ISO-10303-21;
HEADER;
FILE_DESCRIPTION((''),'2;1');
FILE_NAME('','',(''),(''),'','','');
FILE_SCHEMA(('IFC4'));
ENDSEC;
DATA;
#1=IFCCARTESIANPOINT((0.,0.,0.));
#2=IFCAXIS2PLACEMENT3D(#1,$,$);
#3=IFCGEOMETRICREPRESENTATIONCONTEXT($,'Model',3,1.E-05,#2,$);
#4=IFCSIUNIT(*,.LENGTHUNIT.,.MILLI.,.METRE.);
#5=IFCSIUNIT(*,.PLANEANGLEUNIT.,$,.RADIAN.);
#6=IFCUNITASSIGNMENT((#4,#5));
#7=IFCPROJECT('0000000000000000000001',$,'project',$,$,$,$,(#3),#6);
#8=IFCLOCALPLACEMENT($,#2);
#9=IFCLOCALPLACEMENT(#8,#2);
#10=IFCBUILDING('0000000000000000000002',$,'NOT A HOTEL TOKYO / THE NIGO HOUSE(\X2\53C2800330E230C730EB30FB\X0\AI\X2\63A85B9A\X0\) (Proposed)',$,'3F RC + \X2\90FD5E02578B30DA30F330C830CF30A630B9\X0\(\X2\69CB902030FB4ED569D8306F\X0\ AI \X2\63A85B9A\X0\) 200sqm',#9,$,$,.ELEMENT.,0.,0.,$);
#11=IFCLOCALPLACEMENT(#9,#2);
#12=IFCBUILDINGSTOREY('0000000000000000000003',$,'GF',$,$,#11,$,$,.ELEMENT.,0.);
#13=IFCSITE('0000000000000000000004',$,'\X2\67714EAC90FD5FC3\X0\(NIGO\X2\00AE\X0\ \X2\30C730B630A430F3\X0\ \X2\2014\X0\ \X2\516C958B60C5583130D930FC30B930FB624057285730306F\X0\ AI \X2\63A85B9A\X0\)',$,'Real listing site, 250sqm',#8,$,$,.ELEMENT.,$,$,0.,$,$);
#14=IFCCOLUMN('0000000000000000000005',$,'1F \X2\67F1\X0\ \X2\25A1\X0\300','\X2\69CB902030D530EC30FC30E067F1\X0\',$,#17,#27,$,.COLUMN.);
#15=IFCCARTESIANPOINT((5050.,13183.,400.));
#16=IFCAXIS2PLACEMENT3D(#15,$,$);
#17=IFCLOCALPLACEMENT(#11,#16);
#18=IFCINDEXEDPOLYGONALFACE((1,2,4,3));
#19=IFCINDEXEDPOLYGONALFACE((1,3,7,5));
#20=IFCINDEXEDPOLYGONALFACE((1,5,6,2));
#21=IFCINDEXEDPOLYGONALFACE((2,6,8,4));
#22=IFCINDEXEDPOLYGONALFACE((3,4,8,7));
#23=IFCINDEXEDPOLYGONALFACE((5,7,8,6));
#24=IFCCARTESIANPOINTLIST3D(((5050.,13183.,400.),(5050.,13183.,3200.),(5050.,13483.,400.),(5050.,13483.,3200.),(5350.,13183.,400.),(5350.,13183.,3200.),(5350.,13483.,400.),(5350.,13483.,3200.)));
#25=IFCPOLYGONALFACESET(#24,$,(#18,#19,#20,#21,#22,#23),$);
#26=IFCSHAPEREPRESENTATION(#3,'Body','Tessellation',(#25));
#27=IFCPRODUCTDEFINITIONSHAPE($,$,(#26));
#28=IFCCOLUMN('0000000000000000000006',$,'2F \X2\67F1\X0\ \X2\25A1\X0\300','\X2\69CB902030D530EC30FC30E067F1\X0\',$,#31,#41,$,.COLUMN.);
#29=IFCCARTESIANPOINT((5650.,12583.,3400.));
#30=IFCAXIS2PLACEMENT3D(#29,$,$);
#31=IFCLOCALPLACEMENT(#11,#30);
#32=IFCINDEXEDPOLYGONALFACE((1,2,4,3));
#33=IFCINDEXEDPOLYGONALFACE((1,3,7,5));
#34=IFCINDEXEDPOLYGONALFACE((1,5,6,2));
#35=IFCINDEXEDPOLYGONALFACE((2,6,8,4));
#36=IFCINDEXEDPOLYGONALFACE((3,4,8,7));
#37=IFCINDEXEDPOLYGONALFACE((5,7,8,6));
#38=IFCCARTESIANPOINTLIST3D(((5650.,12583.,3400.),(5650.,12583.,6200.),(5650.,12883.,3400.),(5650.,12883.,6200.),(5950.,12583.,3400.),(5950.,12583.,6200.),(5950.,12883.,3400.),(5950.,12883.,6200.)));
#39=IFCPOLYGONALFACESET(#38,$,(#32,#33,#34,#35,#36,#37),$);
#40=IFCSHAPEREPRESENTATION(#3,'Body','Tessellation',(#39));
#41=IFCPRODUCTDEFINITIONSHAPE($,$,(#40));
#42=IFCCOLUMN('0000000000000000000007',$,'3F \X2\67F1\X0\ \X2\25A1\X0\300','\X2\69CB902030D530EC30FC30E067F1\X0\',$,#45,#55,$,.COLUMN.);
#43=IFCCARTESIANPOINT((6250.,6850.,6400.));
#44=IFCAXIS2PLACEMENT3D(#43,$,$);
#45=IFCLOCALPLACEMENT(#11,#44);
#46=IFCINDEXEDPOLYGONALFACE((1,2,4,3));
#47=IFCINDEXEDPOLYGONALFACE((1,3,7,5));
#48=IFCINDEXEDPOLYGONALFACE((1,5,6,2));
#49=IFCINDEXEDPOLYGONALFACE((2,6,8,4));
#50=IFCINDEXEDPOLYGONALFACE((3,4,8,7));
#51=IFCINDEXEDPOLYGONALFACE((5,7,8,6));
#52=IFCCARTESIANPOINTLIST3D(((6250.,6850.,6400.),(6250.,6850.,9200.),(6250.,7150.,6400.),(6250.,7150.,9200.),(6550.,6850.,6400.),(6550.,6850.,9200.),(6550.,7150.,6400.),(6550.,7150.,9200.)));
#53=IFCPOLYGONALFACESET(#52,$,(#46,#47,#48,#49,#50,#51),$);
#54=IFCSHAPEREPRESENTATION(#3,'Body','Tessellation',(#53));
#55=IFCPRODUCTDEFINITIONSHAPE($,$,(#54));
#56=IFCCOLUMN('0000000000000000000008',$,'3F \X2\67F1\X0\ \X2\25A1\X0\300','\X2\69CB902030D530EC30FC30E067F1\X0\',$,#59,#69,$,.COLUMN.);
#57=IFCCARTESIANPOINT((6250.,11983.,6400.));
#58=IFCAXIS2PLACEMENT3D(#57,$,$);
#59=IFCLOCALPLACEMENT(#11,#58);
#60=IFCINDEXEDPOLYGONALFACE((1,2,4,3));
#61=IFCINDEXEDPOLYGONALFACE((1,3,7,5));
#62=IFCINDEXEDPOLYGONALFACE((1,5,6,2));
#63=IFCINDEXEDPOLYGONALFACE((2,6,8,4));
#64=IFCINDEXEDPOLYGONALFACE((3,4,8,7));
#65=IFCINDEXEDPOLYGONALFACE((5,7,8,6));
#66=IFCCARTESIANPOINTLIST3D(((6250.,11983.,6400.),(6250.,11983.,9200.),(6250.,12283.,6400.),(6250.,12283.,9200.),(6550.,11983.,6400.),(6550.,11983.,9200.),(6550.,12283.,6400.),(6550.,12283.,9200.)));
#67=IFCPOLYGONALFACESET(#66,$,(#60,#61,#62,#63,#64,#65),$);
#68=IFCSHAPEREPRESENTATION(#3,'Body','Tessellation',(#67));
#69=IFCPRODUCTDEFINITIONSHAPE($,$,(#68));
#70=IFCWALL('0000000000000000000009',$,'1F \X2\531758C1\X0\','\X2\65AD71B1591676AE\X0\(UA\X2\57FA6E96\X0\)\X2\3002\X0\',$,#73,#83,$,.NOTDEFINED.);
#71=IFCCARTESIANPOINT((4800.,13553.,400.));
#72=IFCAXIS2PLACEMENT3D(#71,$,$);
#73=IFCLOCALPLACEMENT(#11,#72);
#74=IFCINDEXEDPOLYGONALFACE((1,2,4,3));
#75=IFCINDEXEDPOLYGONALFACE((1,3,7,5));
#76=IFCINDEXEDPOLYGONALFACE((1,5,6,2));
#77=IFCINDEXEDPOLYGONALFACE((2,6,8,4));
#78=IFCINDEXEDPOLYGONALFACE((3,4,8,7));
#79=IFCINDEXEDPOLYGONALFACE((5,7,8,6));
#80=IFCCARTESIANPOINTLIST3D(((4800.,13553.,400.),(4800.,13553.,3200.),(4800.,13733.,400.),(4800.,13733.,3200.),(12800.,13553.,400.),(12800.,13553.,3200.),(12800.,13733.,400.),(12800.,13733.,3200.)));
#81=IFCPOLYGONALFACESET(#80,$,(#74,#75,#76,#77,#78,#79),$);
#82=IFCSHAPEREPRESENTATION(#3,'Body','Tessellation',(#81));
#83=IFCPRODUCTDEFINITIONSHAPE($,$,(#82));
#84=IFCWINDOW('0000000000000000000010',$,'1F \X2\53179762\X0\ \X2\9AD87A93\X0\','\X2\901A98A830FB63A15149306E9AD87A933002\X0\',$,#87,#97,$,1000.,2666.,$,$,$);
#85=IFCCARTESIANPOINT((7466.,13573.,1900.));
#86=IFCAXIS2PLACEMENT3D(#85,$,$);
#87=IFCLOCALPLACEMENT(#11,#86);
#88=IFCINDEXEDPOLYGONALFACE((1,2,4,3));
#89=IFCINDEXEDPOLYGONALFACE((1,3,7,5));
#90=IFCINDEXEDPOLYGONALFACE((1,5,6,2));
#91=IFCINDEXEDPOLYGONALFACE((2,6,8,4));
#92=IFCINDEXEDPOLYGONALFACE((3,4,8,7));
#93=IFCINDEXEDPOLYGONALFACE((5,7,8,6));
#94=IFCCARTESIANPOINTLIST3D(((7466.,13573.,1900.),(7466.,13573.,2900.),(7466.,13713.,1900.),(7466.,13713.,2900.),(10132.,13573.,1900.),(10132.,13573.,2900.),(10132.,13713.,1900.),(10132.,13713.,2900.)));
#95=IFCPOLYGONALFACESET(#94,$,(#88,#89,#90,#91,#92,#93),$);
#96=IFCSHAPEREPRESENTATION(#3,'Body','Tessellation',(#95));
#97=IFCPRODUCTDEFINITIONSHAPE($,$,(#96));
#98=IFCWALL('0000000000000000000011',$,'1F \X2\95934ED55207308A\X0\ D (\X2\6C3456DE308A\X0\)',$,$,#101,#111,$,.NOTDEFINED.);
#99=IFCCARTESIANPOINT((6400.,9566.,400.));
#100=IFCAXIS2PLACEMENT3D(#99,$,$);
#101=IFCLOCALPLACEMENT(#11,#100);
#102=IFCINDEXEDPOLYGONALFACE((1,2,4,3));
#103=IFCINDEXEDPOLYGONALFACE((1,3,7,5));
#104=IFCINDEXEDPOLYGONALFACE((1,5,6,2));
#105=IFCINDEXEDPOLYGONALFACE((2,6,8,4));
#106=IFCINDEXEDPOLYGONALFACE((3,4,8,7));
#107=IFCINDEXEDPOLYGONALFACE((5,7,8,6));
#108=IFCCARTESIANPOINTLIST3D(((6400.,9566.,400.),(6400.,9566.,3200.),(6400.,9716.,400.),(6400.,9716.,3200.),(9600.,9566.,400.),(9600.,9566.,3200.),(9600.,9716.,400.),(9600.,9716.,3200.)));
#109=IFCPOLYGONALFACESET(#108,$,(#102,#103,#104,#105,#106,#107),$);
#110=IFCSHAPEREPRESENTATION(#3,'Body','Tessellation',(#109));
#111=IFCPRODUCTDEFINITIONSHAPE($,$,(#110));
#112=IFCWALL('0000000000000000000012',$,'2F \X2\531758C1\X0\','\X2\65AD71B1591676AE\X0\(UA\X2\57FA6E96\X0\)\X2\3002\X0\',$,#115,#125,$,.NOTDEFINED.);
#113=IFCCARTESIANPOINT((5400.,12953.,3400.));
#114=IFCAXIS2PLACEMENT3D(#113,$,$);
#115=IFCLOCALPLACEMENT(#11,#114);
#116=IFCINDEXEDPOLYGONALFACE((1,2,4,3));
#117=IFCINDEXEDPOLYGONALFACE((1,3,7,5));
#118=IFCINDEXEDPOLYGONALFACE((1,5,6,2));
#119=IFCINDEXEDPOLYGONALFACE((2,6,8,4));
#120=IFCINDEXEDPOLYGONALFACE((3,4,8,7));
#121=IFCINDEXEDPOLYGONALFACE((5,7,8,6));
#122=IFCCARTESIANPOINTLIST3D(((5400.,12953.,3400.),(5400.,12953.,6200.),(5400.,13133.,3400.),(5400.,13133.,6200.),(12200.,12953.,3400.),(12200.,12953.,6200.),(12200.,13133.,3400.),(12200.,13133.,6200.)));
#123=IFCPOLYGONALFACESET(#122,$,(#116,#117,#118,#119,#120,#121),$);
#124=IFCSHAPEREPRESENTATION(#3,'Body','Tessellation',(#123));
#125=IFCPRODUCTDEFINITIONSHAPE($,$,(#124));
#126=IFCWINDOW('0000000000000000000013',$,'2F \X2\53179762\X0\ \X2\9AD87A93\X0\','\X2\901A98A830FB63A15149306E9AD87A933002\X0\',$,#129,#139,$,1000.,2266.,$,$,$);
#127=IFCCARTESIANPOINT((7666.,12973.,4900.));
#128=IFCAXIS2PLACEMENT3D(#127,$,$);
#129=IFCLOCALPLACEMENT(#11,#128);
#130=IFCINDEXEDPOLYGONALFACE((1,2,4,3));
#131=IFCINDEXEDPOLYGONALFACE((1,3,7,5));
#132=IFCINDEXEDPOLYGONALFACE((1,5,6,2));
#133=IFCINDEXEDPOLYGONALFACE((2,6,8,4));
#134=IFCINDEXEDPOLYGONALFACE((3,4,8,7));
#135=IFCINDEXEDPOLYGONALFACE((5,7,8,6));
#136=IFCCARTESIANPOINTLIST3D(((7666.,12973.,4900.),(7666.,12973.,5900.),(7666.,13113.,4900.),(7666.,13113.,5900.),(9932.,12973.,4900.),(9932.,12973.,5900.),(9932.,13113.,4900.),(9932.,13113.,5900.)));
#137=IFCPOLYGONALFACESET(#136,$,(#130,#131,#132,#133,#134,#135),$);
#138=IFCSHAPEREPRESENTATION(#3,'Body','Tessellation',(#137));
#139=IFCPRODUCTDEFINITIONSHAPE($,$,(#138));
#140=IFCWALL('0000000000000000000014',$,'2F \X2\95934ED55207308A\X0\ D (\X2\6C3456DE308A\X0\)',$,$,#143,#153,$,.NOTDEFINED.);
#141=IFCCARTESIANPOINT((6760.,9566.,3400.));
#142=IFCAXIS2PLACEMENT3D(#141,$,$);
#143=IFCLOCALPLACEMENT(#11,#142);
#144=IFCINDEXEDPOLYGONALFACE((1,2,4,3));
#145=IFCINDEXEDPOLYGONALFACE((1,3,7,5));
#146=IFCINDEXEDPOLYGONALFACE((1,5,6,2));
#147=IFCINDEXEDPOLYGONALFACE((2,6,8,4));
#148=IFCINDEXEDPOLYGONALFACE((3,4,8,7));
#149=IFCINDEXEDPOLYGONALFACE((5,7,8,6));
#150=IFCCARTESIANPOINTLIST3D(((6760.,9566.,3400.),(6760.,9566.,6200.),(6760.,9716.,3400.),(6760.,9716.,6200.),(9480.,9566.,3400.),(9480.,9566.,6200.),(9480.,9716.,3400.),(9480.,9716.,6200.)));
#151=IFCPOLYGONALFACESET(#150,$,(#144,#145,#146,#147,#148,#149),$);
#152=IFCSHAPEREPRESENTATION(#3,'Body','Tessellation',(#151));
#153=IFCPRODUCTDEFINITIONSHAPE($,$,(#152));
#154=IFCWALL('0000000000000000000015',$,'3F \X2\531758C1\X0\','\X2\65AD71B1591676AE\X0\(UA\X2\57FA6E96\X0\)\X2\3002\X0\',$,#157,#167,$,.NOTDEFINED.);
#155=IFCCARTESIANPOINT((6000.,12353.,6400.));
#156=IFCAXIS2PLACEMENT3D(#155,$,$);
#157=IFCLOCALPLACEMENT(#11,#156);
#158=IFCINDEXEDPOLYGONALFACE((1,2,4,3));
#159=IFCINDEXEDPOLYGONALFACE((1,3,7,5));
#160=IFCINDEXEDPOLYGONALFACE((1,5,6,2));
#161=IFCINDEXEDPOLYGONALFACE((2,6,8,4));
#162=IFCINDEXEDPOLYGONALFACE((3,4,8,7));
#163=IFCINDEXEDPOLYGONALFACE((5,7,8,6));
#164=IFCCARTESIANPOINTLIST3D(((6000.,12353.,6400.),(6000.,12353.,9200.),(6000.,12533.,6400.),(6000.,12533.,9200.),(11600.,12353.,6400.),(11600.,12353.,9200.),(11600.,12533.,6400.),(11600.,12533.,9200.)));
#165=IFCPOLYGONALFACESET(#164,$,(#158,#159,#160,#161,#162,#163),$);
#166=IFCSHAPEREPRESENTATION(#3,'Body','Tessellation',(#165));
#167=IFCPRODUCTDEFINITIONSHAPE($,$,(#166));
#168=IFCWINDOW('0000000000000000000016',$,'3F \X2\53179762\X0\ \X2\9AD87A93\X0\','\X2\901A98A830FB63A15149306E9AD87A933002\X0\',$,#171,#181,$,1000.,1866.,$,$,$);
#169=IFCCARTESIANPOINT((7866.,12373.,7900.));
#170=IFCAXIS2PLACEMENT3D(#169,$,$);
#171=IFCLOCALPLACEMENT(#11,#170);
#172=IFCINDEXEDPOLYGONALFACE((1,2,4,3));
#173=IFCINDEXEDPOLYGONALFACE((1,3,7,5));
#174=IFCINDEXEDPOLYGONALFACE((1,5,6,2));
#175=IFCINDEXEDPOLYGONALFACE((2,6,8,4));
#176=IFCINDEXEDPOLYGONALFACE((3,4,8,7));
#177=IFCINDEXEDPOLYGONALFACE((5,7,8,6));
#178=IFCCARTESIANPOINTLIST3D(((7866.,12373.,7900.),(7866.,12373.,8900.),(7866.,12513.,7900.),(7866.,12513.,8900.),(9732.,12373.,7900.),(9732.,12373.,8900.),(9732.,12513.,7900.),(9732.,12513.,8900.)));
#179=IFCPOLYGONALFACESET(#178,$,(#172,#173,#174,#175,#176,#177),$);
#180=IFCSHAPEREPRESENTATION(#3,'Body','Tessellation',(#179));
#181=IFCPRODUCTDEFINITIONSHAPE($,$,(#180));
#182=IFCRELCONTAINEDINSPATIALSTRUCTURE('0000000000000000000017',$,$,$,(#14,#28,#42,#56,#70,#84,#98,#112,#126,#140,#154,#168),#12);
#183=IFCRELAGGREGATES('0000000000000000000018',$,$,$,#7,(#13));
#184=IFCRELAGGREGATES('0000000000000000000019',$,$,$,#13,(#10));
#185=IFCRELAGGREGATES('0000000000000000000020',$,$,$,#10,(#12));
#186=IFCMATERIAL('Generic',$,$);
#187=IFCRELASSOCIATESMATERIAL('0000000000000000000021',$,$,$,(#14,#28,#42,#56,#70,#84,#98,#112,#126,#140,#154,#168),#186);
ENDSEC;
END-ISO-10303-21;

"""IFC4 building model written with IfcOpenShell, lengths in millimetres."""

from ifc_helpers import new_model, si_unit, frame, frame_2d, origin, place, context, project, spatial, rectangle, extrude, material, element, fill, save


model = new_model("IFC4")

# Units and contexts
model_context = context("Model", 3, precision=1e-05, world=origin())
ifc_project = project(units=[si_unit("LENGTHUNIT", "METRE", prefix="MILLI"), si_unit("PLANEANGLEUNIT", "RADIAN")], contexts=[model_context])

# Site, building, storey
site_placement = place(None, origin())
site = spatial("IfcSite", under=ifc_project, at=site_placement, Name="東京都心(NIGO® デザイン — 公開情報ベース・所在地は AI 推定)", ObjectType="Real listing site, 250sqm", CompositionType="ELEMENT", RefElevation=0.0)
building_placement = place(site_placement, origin())
building = spatial("IfcBuilding", under=site, at=building_placement, Name="NOT A HOTEL TOKYO / THE NIGO HOUSE(参考モデル・AI推定) (Proposed)", ObjectType="3F RC + 都市型ペントハウス(構造・仕様は AI 推定) 200sqm", CompositionType="ELEMENT", ElevationOfRefHeight=0.0, ElevationOfTerrain=0.0)
storey_placement = place(building_placement, origin())
storey = spatial("IfcBuildingStorey", under=building, at=storey_placement, Name="GF", CompositionType="ELEMENT", Elevation=0.0)

# Columns
ifc_material_1 = material(Name="Generic")
column_1_placement = place(storey_placement, frame((5050.0, 13183.0, 400.0)))
element("IfcColumn", 1, at=column_1_placement, inside=storey, material=ifc_material_1, Name="1F 柱 □300", Description="構造フレーム柱", PredefinedType="COLUMN", context=model_context, shape_type="SweptSolid", body=[
    extrude(rectangle(XDim=300.0, YDim=300.0, at=frame_2d((150.0, 150.0))), frame((5050.0, 13183.0, 400.0)), (0.0, 0.0, 1.0), 2800.0),
])
column_2_placement = place(storey_placement, frame((5650.0, 12583.0, 3400.0)))
element("IfcColumn", 2, at=column_2_placement, inside=storey, material=ifc_material_1, Name="2F 柱 □300", Description="構造フレーム柱", PredefinedType="COLUMN", context=model_context, shape_type="SweptSolid", body=[
    extrude(rectangle(XDim=300.0, YDim=300.0, at=frame_2d((150.0, 150.0))), frame((5650.0, 12583.0, 3400.0)), (0.0, 0.0, 1.0), 2800.0),
])
column_3_placement = place(storey_placement, frame((6250.0, 6850.0, 6400.0)))
element("IfcColumn", 3, at=column_3_placement, inside=storey, material=ifc_material_1, Name="3F 柱 □300", Description="構造フレーム柱", PredefinedType="COLUMN", context=model_context, shape_type="SweptSolid", body=[
    extrude(rectangle(XDim=300.0, YDim=300.0, at=frame_2d((150.0, 150.0))), frame((6250.0, 6850.0, 6400.0)), (0.0, 0.0, 1.0), 2800.0),
])
column_4_placement = place(storey_placement, frame((6250.0, 11983.0, 6400.0)))
element("IfcColumn", 4, at=column_4_placement, inside=storey, material=ifc_material_1, Name="3F 柱 □300", Description="構造フレーム柱", PredefinedType="COLUMN", context=model_context, shape_type="SweptSolid", body=[
    extrude(rectangle(XDim=300.0, YDim=300.0, at=frame_2d((150.0, 150.0))), frame((6250.0, 11983.0, 6400.0)), (0.0, 0.0, 1.0), 2800.0),
])

# Wall, opening, window
wall_1_placement = place(storey_placement, frame((4800.0, 13553.0, 400.0)))
wall_1 = element("IfcWall", 5, at=wall_1_placement, inside=storey, material=ifc_material_1, Name="1F 北壁", Description="断熱外皮(UA基準)。", PredefinedType="NOTDEFINED", context=model_context, shape_type="SweptSolid", body=[
    extrude(rectangle(XDim=8000.0, YDim=180.0, at=frame_2d((4000.0, 90.0))), frame((4800.0, 13553.0, 400.0)), (0.0, 0.0, 1.0), 2800.0),
])
opening_1_placement = place(storey_placement, frame((7466.0, 13573.0, 1900.0)))
opening_1 = element("IfcOpeningElement", 6, at=opening_1_placement, cuts=wall_1, PredefinedType="NOTDEFINED", context=model_context, shape_type="SweptSolid", body=[
    extrude(rectangle(XDim=2666.0, YDim=140.0, at=frame_2d((1333.0, 70.0))), frame((7466.0, 13573.0, 1900.0)), (0.0, 0.0, 1.0), 1000.0),
])
window_1_placement = place(storey_placement, frame((7466.0, 13573.0, 1900.0)))
window_1 = element("IfcWindow", 7, at=window_1_placement, inside=storey, material=ifc_material_1, Name="1F 北面 高窓", Description="通風・採光の高窓。", OverallHeight=1000.0, OverallWidth=2666.0, context=model_context, shape_type="SweptSolid", body=[
    extrude(rectangle(XDim=2666.0, YDim=140.0, at=frame_2d((1333.0, 70.0))), frame((7466.0, 13573.0, 1900.0)), (0.0, 0.0, 1.0), 1000.0),
])
fill(opening_1, window_1)

# Wall
wall_2_placement = place(storey_placement, frame((6400.0, 9566.0, 400.0)))
element("IfcWall", 8, at=wall_2_placement, inside=storey, material=ifc_material_1, Name="1F 間仕切り D (水回り)", PredefinedType="NOTDEFINED", context=model_context, shape_type="SweptSolid", body=[
    extrude(rectangle(XDim=3200.0, YDim=150.0, at=frame_2d((1600.0, 75.0))), frame((6400.0, 9566.0, 400.0)), (0.0, 0.0, 1.0), 2800.0),
])

# Wall, opening, window
wall_3_placement = place(storey_placement, frame((5400.0, 12953.0, 3400.0)))
wall_3 = element("IfcWall", 9, at=wall_3_placement, inside=storey, material=ifc_material_1, Name="2F 北壁", Description="断熱外皮(UA基準)。", PredefinedType="NOTDEFINED", context=model_context, shape_type="SweptSolid", body=[
    extrude(rectangle(XDim=6800.0, YDim=180.0, at=frame_2d((3400.0, 90.0))), frame((5400.0, 12953.0, 3400.0)), (0.0, 0.0, 1.0), 2800.0),
])
opening_2_placement = place(storey_placement, frame((7666.0, 12973.0, 4900.0)))
opening_2 = element("IfcOpeningElement", 10, at=opening_2_placement, cuts=wall_3, PredefinedType="NOTDEFINED", context=model_context, shape_type="SweptSolid", body=[
    extrude(rectangle(XDim=2266.0, YDim=140.0, at=frame_2d((1133.0, 70.0))), frame((7666.0, 12973.0, 4900.0)), (0.0, 0.0, 1.0), 1000.0),
])
window_2_placement = place(storey_placement, frame((7666.0, 12973.0, 4900.0)))
window_2 = element("IfcWindow", 11, at=window_2_placement, inside=storey, material=ifc_material_1, Name="2F 北面 高窓", Description="通風・採光の高窓。", OverallHeight=1000.0, OverallWidth=2266.0, context=model_context, shape_type="SweptSolid", body=[
    extrude(rectangle(XDim=2266.0, YDim=140.0, at=frame_2d((1133.0, 70.0))), frame((7666.0, 12973.0, 4900.0)), (0.0, 0.0, 1.0), 1000.0),
])
fill(opening_2, window_2)

# Wall
wall_4_placement = place(storey_placement, frame((6760.0, 9566.0, 3400.0)))
element("IfcWall", 12, at=wall_4_placement, inside=storey, material=ifc_material_1, Name="2F 間仕切り D (水回り)", PredefinedType="NOTDEFINED", context=model_context, shape_type="SweptSolid", body=[
    extrude(rectangle(XDim=2720.0, YDim=150.0, at=frame_2d((1360.0, 75.0))), frame((6760.0, 9566.0, 3400.0)), (0.0, 0.0, 1.0), 2800.0),
])

# Wall, opening, window
wall_5_placement = place(storey_placement, frame((6000.0, 12353.0, 6400.0)))
wall_5 = element("IfcWall", 13, at=wall_5_placement, inside=storey, material=ifc_material_1, Name="3F 北壁", Description="断熱外皮(UA基準)。", PredefinedType="NOTDEFINED", context=model_context, shape_type="SweptSolid", body=[
    extrude(rectangle(XDim=5600.0, YDim=180.0, at=frame_2d((2800.0, 90.0))), frame((6000.0, 12353.0, 6400.0)), (0.0, 0.0, 1.0), 2800.0),
])
opening_3_placement = place(storey_placement, frame((7866.0, 12373.0, 7900.0)))
opening_3 = element("IfcOpeningElement", 14, at=opening_3_placement, cuts=wall_5, PredefinedType="NOTDEFINED", context=model_context, shape_type="SweptSolid", body=[
    extrude(rectangle(XDim=1866.0, YDim=140.0, at=frame_2d((933.0, 70.0))), frame((7866.0, 12373.0, 7900.0)), (0.0, 0.0, 1.0), 1000.0),
])
window_3_placement = place(storey_placement, frame((7866.0, 12373.0, 7900.0)))
window_3 = element("IfcWindow", 15, at=window_3_placement, inside=storey, material=ifc_material_1, Name="3F 北面 高窓", Description="通風・採光の高窓。", OverallHeight=1000.0, OverallWidth=1866.0, context=model_context, shape_type="SweptSolid", body=[
    extrude(rectangle(XDim=1866.0, YDim=140.0, at=frame_2d((933.0, 70.0))), frame((7866.0, 12373.0, 7900.0)), (0.0, 0.0, 1.0), 1000.0),
])
fill(opening_3, window_3)

save(model, "model.ifc")
